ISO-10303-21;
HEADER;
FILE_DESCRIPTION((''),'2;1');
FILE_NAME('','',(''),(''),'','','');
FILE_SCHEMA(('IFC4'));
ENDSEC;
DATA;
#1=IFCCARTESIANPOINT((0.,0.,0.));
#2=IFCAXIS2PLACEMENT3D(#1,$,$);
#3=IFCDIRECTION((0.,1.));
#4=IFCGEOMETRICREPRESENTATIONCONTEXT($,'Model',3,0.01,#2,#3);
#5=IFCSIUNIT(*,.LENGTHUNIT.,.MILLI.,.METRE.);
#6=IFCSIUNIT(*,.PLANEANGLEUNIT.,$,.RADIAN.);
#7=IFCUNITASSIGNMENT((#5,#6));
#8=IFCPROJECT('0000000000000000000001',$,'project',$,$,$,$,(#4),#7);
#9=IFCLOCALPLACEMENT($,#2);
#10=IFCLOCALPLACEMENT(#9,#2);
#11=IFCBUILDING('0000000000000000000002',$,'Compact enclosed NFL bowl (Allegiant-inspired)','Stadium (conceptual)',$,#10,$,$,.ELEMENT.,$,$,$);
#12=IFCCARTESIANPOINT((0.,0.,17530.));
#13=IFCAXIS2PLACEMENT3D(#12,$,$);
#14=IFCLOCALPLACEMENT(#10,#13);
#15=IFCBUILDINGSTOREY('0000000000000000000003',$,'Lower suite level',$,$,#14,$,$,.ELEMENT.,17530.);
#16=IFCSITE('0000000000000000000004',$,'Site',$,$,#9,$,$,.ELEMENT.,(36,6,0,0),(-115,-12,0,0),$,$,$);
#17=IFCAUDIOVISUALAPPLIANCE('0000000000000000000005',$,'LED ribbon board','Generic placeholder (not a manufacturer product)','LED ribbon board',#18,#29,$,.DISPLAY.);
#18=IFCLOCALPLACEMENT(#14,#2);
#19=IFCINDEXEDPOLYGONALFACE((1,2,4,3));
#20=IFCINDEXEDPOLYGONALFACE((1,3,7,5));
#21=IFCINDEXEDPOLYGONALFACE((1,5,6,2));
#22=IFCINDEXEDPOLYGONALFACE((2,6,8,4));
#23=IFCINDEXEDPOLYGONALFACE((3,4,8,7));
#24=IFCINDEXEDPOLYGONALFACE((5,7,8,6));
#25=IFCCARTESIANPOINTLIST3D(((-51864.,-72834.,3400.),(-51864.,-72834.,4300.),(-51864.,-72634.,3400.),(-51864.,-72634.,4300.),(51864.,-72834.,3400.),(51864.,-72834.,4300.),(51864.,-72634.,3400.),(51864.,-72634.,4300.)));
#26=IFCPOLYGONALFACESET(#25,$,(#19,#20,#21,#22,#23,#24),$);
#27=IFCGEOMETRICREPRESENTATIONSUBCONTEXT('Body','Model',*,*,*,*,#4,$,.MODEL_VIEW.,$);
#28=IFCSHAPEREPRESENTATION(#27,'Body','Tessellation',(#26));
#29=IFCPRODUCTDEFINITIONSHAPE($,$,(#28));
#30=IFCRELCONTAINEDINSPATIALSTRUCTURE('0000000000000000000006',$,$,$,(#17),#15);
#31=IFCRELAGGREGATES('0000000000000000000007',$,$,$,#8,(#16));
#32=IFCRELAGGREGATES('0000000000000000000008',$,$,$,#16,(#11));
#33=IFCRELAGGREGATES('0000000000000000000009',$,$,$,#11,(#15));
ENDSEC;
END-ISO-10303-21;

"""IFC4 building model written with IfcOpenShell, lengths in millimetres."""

from ifc_helpers import new_model, si_unit, direction, frame, origin, place, context, subcontext, project, spatial, line, indexed_curve, outline, extrude, element, save


model = new_model("IFC4")

# Units and contexts
model_context = context("Model", 3, precision=0.01, world=origin(), true_north=direction((0.0, 1.0)))
body_context = subcontext(model_context, "Body", "Model", "MODEL_VIEW")
ifc_project = project(units=[si_unit("LENGTHUNIT", "METRE", prefix="MILLI"), si_unit("PLANEANGLEUNIT", "RADIAN")], contexts=[model_context])

# Site, building, storey
site_placement = place(None, origin())
site = spatial("IfcSite", under=ifc_project, at=site_placement, Name="Site", CompositionType="ELEMENT", RefLatitude=(36, 6, 0, 0), RefLongitude=(-115, -12, 0, 0))
building_placement = place(site_placement, origin())
building = spatial("IfcBuilding", under=site, at=building_placement, Name="Compact enclosed NFL bowl (Allegiant-inspired)", Description="Stadium (conceptual)", CompositionType="ELEMENT")
storey_placement = place(building_placement, frame((0.0, 0.0, 17530.0)))
storey = spatial("IfcBuildingStorey", under=building, at=storey_placement, Name="Lower suite level", CompositionType="ELEMENT", Elevation=17530.0)

# Shared definitions
placement = place(storey_placement, frame((0.0, 0.0, -17530.0)))

# Audio visual appliance
element("IfcAudioVisualAppliance", 1, at=placement, inside=storey, Name="LED ribbon board", Description="Generic placeholder (not a manufacturer product)", ObjectType="LED ribbon board", PredefinedType="DISPLAY", context=body_context, shape_type="SweptSolid", body=[
    extrude(outline(indexed_curve([(-51864.0, -72634.0), (51864.0, -72634.0), (51864.0, -72834.0), (-51864.0, -72834.0)], segments=[line(1, 2), line(2, 3), line(3, 4), line(4, 1)], self_intersect=False)), frame((0.0, 0.0, 20930.0)), (0.0, 0.0, 1.0), 900.0),
])

save(model, "model.ifc")
